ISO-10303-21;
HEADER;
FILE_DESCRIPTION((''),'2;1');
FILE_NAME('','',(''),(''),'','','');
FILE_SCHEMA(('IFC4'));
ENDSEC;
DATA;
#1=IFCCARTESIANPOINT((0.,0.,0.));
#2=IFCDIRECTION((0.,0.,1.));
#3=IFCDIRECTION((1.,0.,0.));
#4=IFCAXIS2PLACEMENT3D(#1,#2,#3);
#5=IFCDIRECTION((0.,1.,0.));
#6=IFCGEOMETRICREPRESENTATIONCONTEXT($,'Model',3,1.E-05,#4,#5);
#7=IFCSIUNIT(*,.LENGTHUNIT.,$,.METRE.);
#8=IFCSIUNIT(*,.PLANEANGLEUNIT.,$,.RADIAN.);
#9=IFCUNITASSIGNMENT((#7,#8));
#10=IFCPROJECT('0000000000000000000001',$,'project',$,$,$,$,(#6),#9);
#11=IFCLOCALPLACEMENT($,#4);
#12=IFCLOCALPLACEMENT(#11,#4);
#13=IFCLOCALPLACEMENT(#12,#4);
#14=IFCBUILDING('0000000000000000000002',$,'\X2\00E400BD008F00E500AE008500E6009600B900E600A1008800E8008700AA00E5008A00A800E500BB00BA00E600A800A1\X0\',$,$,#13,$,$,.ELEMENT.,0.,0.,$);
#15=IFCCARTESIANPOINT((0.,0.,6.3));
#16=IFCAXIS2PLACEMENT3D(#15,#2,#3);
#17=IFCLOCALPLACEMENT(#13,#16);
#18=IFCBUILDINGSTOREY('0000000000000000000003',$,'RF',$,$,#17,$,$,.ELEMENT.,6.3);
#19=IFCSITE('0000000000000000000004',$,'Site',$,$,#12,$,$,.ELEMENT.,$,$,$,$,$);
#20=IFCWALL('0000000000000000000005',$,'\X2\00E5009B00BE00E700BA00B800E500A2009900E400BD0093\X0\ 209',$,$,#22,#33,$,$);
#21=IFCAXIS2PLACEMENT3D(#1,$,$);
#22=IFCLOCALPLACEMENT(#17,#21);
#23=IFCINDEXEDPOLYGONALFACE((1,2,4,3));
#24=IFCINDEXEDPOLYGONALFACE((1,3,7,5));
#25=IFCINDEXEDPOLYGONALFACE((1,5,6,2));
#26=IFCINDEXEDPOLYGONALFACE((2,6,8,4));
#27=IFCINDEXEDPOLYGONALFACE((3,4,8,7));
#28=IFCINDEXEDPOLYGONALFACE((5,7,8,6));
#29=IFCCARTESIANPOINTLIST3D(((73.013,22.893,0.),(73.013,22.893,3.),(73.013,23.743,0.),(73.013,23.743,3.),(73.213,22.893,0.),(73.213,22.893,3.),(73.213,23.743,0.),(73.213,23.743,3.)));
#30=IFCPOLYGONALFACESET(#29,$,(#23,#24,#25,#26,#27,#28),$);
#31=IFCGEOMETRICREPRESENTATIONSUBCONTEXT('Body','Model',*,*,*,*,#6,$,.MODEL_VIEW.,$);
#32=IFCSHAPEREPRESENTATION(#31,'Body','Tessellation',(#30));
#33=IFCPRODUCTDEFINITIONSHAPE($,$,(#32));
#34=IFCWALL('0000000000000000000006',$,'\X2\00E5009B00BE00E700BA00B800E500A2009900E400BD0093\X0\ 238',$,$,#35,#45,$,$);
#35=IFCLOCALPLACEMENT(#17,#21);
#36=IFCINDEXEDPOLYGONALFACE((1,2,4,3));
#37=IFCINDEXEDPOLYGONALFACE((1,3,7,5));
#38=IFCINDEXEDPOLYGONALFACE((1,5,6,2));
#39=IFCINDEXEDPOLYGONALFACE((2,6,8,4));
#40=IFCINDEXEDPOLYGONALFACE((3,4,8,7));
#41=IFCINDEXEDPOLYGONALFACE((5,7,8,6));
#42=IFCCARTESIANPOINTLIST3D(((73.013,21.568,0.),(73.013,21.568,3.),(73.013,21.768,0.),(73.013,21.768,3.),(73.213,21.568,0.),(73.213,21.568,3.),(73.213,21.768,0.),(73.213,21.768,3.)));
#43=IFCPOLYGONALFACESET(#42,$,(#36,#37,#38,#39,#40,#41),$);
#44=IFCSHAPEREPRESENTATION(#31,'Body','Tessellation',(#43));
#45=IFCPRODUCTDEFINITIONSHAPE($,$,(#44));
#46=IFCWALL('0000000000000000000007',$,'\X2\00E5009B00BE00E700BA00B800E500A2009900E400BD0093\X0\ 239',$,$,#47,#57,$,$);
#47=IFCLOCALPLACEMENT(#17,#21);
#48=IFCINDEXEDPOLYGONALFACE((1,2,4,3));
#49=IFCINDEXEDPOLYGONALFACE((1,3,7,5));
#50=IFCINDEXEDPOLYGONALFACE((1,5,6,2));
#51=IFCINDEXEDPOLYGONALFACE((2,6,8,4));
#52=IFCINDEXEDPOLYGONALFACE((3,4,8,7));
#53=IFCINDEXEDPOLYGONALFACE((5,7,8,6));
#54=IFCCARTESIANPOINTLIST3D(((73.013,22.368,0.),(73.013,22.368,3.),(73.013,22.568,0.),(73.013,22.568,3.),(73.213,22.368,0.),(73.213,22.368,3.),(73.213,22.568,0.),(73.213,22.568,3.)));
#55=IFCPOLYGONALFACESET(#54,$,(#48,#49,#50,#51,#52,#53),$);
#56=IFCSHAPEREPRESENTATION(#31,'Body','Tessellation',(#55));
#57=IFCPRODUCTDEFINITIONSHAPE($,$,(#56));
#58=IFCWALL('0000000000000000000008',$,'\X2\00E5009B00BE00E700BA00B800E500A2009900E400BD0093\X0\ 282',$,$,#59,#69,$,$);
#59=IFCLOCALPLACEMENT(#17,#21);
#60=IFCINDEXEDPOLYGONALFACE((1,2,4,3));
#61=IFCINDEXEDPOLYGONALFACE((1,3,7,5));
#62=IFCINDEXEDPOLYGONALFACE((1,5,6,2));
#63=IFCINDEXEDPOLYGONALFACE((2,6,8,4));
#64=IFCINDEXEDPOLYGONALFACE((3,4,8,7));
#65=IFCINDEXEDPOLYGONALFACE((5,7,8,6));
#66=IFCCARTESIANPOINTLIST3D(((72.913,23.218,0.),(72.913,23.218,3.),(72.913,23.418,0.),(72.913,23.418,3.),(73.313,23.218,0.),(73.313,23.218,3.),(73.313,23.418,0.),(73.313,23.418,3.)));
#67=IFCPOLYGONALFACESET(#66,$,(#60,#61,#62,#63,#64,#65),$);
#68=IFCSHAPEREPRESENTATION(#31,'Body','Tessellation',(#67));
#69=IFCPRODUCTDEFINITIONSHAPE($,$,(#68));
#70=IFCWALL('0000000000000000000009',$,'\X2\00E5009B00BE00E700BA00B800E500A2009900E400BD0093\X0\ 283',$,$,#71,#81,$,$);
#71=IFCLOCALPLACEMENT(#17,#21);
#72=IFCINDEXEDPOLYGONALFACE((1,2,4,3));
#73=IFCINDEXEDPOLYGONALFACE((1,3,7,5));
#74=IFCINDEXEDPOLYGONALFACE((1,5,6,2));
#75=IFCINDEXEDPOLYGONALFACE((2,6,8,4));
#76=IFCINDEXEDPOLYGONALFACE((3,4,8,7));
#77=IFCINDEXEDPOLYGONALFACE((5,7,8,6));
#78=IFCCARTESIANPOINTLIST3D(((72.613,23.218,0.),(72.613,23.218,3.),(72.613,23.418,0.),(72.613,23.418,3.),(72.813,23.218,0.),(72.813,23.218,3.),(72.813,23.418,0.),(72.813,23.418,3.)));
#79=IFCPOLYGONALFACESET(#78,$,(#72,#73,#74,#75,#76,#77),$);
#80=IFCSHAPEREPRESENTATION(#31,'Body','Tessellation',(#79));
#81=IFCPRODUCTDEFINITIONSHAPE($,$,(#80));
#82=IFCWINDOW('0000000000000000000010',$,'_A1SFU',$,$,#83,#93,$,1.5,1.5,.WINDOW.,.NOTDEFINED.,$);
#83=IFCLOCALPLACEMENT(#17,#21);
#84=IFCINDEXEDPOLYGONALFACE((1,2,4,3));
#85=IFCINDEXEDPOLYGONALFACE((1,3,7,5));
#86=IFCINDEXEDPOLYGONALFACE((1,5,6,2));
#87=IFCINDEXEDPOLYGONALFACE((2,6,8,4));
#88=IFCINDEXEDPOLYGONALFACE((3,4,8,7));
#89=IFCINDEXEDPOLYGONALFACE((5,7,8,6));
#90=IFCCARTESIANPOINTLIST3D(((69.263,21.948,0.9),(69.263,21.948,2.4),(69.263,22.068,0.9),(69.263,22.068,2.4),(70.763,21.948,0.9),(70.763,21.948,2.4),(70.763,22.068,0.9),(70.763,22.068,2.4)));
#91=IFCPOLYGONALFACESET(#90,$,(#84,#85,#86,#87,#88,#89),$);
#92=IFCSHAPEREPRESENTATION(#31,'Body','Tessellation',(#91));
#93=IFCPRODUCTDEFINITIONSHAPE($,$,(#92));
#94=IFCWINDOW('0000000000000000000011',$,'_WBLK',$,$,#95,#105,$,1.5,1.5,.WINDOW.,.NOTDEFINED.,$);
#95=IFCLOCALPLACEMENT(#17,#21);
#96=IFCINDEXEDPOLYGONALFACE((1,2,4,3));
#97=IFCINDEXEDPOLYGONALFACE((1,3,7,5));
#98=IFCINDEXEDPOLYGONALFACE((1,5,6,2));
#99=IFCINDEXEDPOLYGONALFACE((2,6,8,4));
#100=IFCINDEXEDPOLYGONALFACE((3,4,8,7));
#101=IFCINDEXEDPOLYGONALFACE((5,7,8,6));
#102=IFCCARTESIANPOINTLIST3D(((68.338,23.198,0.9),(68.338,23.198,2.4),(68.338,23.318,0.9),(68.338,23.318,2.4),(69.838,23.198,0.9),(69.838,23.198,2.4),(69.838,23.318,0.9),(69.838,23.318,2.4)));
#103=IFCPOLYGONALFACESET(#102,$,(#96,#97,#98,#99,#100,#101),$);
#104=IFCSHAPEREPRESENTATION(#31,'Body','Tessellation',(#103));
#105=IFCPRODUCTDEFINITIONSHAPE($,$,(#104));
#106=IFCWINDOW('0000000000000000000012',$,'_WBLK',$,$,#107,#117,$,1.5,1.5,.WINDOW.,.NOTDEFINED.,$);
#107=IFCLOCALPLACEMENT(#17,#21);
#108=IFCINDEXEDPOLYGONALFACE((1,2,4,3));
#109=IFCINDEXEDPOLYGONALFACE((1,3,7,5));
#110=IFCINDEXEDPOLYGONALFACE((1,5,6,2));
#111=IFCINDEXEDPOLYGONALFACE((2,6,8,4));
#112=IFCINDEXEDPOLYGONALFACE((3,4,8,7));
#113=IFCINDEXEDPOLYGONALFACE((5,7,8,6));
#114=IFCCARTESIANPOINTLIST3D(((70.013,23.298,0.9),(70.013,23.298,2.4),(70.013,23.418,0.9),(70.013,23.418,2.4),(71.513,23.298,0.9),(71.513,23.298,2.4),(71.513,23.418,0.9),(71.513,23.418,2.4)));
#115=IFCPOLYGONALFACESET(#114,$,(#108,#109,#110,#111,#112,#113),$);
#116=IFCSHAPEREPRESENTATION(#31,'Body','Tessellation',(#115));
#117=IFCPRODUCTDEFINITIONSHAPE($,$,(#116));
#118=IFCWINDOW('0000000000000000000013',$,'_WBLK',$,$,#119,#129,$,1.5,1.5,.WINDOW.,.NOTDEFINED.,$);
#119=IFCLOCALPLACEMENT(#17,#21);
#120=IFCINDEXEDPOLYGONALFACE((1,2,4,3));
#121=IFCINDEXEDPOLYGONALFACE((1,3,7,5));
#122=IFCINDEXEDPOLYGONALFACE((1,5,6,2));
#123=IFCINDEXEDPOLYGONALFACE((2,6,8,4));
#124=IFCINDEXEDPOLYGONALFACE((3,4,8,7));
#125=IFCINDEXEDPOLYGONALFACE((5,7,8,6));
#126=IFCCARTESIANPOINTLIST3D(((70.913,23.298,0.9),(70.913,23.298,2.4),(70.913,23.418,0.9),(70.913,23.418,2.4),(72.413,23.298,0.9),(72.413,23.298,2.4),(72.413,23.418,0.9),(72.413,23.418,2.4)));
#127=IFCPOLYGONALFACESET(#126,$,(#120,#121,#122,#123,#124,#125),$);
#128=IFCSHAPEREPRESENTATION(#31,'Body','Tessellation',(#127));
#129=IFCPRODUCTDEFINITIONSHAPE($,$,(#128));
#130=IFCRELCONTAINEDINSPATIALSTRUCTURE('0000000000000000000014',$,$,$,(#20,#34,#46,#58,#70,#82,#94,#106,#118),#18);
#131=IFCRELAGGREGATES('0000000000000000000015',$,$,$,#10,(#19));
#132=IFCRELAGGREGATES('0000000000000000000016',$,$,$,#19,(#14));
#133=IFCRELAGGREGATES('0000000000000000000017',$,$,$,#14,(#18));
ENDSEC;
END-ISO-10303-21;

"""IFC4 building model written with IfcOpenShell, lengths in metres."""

from ifc_helpers import new_model, si_unit, direction, frame, frame_2d, origin_with_axes, place, context, subcontext, project, spatial, rectangle, extrude, element, save


model = new_model("IFC4")

# Units and contexts
model_context = context("Model", 3, precision=1e-05, world=origin_with_axes(), true_north=direction((0.0, 1.0, 0.0)))
body_context = subcontext(model_context, "Body", "Model", "MODEL_VIEW")
ifc_project = project(units=[si_unit("LENGTHUNIT", "METRE"), si_unit("PLANEANGLEUNIT", "RADIAN")], contexts=[model_context])

# Site, building, storey
placement = place(None, origin_with_axes())
site_placement = place(placement, origin_with_axes())
site = spatial("IfcSite", under=ifc_project, at=site_placement, Name="Site", CompositionType="ELEMENT")
building_placement = place(site_placement, origin_with_axes())
building = spatial("IfcBuilding", under=site, at=building_placement, Name="ä½\u008få®\u0085æ\u0096¹æ¡\u0088è\u0087ªå\u008a¨å»ºæ¨¡", CompositionType="ELEMENT", ElevationOfRefHeight=0.0, ElevationOfTerrain=0.0)
storey_placement = place(building_placement, frame((0.0, 0.0, 6.3), z_axis=(0.0, 0.0, 1.0), x_axis=(1.0, 0.0, 0.0)))
storey = spatial("IfcBuildingStorey", under=building, at=storey_placement, Name="RF", CompositionType="ELEMENT", Elevation=6.3)

# Walls
for number, where, z_axis, x_axis, name in (
    (1, (73.113, 23.318, 0.0), (0.0, 0.0, 1.0), (0.0, -1.0, 0.0), "å\u009b¾çº¸å¢\u0099ä½\u0093 209"),
):
    element("IfcWall", number, at=place(storey_placement, frame(where, z_axis=z_axis, x_axis=x_axis)), inside=storey, Name=name, context=body_context, shape_type="SweptSolid", body=[
        extrude(rectangle(XDim=0.85, YDim=0.2, at=frame_2d((0.0, 0.0), x_axis=(1.0, 0.0, 0.0))), frame((0.0, 0.0, 0.0), z_axis=(0.0, 0.0, 1.0)), (0.0, 0.0, 1.0), 3.0),
    ])
for number, where, z_axis, x_axis, name in (
    (2, (73.113, 21.668, 0.0), (0.0, 0.0, 1.0), (0.0, -1.0, 0.0), "å\u009b¾çº¸å¢\u0099ä½\u0093 238"),
    (3, (73.113, 22.468, 0.0), (0.0, 0.0, 1.0), (1.0, 0.0, 0.0), "å\u009b¾çº¸å¢\u0099ä½\u0093 239"),
):
    element("IfcWall", number, at=place(storey_placement, frame(where, z_axis=z_axis, x_axis=x_axis)), inside=storey, Name=name, context=body_context, shape_type="SweptSolid", body=[
        extrude(rectangle(XDim=0.2, YDim=0.2, at=frame_2d((0.0, 0.0), x_axis=(1.0, 0.0, 0.0))), frame((0.0, 0.0, 0.0), z_axis=(0.0, 0.0, 1.0)), (0.0, 0.0, 1.0), 3.0),
    ])
wall_1_placement = place(storey_placement, frame((73.113, 23.318, 0.0), z_axis=(0.0, 0.0, 1.0), x_axis=(-1.0, 0.0, 0.0)))
element("IfcWall", 4, at=wall_1_placement, inside=storey, Name="å\u009b¾çº¸å¢\u0099ä½\u0093 282", context=body_context, shape_type="SweptSolid", body=[
    extrude(rectangle(XDim=0.4, YDim=0.2, at=frame_2d((0.0, 0.0), x_axis=(1.0, 0.0, 0.0))), frame((0.0, 0.0, 0.0), z_axis=(0.0, 0.0, 1.0)), (0.0, 0.0, 1.0), 3.0),
])
for number, where, z_axis, x_axis, name in (
    (5, (72.713, 23.318, 0.0), (0.0, 0.0, 1.0), (0.0, 1.0, 0.0), "å\u009b¾çº¸å¢\u0099ä½\u0093 283"),
):
    element("IfcWall", number, at=place(storey_placement, frame(where, z_axis=z_axis, x_axis=x_axis)), inside=storey, Name=name, context=body_context, shape_type="SweptSolid", body=[
        extrude(rectangle(XDim=0.2, YDim=0.2, at=frame_2d((0.0, 0.0), x_axis=(1.0, 0.0, 0.0))), frame((0.0, 0.0, 0.0), z_axis=(0.0, 0.0, 1.0)), (0.0, 0.0, 1.0), 3.0),
    ])

# Windows
for number, where, z_axis, x_axis, name in (
    (6, (70.013, 22.008, 0.9), (0.0, 0.0, 1.0), (1.0, 0.0, 0.0), "_A1SFU"),
    (7, (69.088, 23.258, 0.9), (0.0, 0.0, 1.0), (1.0, 0.0, 0.0), "_WBLK"),
    (8, (70.763, 23.358, 0.9), (0.0, 0.0, 1.0), (1.0, 0.0, 0.0), "_WBLK"),
    (9, (71.663, 23.358, 0.9), (0.0, 0.0, 1.0), (1.0, 0.0, 0.0), "_WBLK"),
):
    element("IfcWindow", number, at=place(storey_placement, frame(where, z_axis=z_axis, x_axis=x_axis)), inside=storey, Name=name, OverallHeight=1.5, OverallWidth=1.5, PartitioningType="NOTDEFINED", PredefinedType="WINDOW", context=body_context, shape_type="SweptSolid", body=[
        extrude(rectangle(XDim=1.5, YDim=0.12, at=frame_2d((0.0, 0.0), x_axis=(1.0, 0.0, 0.0))), frame((0.0, 0.0, 0.0), z_axis=(0.0, 0.0, 1.0)), (0.0, 0.0, 1.0), 1.5),
    ])

save(model, "model.ifc")
